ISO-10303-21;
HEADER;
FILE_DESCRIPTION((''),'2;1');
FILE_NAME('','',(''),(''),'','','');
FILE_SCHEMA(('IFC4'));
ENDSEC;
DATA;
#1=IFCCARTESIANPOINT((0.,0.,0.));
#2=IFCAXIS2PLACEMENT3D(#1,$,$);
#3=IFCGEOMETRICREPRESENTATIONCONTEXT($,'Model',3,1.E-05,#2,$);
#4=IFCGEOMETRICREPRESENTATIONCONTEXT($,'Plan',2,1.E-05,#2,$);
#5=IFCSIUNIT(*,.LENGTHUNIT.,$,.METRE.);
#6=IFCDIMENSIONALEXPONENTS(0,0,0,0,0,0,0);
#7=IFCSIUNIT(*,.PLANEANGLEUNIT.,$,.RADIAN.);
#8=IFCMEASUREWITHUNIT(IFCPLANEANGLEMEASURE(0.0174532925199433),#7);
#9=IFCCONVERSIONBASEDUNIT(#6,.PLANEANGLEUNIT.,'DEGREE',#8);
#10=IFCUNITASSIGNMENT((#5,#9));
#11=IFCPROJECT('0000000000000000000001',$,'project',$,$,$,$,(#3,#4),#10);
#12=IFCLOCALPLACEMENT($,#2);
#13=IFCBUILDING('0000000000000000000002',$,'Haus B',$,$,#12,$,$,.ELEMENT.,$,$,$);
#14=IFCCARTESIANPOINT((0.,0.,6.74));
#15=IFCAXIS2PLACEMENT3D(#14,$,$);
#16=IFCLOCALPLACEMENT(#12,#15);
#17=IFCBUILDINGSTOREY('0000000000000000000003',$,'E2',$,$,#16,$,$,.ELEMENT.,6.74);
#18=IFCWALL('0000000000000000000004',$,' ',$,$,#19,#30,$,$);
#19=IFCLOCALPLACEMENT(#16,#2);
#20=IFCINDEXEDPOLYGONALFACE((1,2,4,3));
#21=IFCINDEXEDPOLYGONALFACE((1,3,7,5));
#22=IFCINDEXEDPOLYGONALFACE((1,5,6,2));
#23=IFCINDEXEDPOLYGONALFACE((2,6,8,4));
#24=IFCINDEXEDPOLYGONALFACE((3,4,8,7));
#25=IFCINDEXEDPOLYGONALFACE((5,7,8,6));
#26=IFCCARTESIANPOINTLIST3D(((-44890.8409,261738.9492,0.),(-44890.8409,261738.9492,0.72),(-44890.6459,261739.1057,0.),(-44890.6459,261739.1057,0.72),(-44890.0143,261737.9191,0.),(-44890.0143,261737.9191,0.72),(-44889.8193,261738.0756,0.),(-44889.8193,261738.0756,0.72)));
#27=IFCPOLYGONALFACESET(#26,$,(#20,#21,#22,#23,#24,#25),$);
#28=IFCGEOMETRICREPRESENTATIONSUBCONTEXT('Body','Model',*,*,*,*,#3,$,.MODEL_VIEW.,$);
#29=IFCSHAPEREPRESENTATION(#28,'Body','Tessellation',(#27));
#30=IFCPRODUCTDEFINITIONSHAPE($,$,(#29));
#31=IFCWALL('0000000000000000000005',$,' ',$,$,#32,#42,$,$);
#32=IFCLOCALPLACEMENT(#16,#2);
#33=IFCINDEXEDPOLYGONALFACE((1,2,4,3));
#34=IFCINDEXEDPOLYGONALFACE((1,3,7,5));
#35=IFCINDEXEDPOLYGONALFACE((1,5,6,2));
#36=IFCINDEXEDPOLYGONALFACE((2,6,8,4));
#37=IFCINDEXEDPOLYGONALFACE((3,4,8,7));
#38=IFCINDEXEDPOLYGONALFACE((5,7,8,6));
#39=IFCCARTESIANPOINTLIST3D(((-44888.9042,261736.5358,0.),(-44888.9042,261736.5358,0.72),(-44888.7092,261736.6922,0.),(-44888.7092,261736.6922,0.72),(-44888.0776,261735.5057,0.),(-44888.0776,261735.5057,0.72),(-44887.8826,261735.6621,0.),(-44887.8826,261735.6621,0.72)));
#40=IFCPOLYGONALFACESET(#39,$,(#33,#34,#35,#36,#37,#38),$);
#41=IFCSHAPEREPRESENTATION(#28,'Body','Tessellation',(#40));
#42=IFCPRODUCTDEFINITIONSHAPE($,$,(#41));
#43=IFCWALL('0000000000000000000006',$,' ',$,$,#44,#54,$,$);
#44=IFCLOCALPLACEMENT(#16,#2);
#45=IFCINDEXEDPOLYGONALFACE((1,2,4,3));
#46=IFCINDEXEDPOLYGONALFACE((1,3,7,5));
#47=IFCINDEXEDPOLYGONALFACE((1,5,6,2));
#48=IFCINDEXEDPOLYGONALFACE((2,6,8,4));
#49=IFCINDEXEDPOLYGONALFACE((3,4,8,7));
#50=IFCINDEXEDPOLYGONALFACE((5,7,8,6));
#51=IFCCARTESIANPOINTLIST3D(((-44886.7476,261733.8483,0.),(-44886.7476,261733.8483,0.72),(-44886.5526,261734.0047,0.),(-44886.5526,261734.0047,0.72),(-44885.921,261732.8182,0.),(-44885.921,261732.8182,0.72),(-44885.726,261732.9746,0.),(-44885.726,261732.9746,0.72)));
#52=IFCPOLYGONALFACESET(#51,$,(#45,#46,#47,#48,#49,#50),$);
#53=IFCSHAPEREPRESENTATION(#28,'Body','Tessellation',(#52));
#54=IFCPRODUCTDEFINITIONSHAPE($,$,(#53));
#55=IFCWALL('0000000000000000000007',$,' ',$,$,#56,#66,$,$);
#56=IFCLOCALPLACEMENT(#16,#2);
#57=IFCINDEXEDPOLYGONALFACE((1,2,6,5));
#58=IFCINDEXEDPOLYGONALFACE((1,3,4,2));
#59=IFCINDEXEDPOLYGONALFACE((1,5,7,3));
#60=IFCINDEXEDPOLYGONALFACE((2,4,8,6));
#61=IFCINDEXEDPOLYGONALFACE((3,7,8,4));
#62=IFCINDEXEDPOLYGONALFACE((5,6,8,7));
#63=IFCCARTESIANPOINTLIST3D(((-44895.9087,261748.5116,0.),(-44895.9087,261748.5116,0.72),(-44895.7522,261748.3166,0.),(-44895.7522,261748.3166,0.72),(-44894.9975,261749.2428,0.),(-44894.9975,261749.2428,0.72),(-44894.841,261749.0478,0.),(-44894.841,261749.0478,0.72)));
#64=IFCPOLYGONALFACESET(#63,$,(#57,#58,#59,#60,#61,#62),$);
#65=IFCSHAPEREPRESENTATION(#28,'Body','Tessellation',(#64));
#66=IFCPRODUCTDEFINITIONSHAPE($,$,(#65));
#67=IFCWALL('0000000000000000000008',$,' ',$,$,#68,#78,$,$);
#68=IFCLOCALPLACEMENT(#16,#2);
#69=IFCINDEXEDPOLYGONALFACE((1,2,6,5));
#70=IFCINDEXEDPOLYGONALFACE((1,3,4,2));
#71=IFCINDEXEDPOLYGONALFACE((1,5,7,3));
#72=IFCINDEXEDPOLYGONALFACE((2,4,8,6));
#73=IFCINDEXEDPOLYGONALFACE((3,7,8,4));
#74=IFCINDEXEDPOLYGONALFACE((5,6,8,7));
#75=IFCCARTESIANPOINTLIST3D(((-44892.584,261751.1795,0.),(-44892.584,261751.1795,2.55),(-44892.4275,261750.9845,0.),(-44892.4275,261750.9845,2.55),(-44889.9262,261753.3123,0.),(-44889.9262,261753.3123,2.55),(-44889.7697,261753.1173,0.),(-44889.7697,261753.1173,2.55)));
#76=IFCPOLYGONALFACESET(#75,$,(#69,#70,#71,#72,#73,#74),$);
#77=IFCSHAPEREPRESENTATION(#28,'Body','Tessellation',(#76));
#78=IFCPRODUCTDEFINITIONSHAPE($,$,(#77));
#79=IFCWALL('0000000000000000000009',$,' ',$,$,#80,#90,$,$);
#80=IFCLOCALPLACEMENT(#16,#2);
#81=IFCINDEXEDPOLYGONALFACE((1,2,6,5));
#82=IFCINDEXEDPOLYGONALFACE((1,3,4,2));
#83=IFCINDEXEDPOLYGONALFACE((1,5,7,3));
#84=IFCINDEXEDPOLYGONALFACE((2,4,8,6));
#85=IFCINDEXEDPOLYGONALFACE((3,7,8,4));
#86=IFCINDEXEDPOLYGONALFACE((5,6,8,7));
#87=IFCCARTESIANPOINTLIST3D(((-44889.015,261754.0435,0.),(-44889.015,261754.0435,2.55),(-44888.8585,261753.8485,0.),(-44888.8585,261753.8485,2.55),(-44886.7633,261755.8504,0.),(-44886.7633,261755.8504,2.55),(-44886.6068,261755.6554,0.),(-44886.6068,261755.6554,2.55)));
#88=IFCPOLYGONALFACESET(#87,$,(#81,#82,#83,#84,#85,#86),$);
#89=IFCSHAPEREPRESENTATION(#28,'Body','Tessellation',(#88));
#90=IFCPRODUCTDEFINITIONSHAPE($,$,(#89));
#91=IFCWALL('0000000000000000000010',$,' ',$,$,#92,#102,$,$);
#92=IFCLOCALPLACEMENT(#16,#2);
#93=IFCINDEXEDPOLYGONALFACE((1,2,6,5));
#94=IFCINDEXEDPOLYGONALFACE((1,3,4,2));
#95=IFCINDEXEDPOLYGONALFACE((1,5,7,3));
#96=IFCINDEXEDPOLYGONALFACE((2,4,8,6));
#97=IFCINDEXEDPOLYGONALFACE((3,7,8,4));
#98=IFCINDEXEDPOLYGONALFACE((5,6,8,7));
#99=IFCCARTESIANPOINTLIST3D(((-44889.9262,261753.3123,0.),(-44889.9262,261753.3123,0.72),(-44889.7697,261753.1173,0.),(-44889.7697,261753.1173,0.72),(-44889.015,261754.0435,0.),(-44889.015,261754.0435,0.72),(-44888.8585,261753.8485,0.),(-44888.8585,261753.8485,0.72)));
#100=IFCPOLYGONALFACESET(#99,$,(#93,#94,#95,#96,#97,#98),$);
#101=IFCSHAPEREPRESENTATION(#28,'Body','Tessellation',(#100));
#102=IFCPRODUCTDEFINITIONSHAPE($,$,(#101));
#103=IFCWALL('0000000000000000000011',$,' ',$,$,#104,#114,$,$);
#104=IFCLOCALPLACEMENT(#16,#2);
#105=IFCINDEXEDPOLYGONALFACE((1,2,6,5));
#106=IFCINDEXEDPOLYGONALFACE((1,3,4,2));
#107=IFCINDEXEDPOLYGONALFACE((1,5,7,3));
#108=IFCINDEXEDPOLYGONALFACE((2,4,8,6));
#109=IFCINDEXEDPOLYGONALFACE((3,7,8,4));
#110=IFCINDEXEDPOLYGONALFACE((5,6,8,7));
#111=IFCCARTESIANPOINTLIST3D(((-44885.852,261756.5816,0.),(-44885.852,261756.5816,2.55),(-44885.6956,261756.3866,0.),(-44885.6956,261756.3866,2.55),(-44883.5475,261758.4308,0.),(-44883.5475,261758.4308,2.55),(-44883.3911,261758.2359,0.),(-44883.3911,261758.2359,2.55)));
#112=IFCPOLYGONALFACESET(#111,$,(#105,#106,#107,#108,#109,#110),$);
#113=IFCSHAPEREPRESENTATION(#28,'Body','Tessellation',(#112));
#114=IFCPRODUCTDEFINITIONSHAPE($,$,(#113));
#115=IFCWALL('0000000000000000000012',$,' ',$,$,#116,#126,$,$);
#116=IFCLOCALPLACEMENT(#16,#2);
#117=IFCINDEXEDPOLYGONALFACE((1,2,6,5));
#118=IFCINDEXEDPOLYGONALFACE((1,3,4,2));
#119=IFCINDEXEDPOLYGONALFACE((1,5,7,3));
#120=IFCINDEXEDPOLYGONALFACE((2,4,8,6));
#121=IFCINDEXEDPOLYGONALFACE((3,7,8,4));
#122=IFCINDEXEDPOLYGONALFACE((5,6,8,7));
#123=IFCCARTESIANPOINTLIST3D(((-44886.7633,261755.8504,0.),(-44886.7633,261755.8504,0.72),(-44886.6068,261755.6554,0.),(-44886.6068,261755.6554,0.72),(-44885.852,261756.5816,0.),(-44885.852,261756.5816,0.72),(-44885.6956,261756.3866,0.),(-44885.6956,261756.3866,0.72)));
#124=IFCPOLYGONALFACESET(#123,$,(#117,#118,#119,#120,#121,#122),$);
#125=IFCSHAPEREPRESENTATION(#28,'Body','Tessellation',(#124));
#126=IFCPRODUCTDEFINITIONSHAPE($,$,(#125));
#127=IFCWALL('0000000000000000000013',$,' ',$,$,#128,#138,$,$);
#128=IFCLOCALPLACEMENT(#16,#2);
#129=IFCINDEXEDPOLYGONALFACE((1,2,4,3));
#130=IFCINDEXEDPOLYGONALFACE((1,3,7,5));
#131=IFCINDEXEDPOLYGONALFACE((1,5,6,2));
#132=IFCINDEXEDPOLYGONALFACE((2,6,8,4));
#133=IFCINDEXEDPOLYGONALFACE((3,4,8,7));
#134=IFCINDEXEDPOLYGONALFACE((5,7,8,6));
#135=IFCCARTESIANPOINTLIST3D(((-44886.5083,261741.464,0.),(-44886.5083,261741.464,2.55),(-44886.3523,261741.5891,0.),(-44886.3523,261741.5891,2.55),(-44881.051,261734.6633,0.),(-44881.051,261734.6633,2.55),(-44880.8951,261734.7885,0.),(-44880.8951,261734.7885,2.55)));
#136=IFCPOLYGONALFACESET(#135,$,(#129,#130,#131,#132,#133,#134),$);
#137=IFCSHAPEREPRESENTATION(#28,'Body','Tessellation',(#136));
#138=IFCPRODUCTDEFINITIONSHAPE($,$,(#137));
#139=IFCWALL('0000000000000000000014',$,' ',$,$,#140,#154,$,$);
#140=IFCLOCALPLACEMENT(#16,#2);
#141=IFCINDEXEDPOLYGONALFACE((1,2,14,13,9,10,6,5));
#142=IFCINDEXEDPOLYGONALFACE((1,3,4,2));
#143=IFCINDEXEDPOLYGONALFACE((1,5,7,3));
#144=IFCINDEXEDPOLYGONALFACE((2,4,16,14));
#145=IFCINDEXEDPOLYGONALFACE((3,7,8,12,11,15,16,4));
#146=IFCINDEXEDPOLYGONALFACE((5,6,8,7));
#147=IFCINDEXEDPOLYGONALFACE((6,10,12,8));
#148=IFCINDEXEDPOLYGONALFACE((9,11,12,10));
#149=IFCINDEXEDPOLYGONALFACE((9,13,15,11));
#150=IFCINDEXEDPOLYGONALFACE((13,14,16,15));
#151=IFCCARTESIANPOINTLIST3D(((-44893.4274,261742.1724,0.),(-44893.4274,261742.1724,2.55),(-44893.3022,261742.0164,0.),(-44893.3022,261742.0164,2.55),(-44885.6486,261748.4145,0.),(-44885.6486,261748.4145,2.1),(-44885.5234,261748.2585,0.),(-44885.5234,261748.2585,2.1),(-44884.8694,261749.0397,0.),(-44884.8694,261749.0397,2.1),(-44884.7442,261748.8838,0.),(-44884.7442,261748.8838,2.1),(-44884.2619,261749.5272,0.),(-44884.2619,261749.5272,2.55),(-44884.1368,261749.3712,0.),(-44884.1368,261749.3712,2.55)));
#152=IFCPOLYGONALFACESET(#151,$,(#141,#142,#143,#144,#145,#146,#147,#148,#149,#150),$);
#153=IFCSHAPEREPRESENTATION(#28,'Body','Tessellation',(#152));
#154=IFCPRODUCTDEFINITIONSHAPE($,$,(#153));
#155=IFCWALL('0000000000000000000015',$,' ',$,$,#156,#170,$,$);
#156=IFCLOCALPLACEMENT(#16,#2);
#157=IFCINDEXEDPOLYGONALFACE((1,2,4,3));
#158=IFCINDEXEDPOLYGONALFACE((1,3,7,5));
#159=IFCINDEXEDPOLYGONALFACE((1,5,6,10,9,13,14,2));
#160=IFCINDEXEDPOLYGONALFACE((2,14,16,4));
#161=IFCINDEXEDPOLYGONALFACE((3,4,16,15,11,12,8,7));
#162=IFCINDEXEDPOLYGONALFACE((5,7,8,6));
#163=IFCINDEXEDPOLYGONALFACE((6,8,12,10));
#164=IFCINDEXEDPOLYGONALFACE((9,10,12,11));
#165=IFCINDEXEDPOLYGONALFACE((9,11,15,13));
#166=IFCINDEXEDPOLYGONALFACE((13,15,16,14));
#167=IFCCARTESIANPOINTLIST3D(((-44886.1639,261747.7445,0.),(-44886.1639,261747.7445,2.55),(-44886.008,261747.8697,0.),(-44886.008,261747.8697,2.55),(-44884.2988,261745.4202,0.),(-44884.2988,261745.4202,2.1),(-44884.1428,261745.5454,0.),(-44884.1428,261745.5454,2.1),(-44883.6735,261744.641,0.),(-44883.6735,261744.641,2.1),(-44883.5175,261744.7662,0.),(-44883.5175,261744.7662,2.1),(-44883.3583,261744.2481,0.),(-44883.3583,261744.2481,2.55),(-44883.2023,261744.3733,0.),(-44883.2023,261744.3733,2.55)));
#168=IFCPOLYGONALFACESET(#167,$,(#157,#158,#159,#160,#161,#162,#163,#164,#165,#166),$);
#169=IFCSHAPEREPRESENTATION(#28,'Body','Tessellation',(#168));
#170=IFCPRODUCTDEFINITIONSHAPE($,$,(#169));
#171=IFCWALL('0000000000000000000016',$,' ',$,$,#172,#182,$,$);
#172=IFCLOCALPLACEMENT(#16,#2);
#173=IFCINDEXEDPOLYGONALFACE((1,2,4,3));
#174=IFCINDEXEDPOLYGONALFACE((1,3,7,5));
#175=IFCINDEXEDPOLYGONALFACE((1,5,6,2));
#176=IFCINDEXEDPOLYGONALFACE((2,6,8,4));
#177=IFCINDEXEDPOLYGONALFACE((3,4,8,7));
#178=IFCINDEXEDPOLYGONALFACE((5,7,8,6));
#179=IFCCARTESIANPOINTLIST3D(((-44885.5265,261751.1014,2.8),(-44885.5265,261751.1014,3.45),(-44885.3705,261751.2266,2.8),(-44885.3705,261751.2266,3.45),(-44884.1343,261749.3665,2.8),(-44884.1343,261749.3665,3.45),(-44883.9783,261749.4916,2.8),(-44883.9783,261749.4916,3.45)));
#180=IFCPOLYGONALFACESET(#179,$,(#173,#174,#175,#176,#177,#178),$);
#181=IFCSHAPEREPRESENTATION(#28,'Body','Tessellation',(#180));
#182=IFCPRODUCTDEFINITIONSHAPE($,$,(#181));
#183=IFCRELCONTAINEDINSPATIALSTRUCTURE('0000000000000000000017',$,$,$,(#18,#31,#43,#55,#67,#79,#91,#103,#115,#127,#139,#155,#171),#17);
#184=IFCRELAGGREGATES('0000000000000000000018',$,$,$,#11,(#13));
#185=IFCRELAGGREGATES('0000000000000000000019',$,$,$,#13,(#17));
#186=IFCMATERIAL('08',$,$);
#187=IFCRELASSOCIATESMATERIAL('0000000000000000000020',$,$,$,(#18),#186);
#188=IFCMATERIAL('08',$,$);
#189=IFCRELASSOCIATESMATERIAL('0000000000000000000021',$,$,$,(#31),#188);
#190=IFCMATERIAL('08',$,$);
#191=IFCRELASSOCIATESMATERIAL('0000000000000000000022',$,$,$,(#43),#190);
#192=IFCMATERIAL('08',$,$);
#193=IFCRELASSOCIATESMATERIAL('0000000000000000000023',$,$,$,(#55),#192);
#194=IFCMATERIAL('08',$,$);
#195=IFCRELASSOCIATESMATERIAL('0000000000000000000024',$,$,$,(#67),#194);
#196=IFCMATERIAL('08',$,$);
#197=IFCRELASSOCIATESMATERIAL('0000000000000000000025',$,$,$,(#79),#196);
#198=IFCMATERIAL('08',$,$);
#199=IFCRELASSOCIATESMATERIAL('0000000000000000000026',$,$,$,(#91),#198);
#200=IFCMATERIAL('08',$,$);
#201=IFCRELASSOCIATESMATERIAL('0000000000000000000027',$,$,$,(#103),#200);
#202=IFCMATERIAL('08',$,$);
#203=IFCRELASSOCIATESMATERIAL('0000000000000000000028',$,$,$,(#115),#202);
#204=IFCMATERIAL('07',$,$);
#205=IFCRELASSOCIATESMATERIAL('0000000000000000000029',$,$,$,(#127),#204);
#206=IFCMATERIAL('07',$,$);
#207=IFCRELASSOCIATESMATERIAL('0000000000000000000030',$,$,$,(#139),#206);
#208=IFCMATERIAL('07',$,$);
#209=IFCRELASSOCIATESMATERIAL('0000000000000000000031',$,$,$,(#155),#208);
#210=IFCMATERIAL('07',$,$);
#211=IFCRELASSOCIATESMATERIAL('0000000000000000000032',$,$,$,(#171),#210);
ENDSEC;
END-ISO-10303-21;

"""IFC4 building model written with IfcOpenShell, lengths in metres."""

from ifc_helpers import new_model, entity, si_unit, converted_unit, frame, frame_2d, origin, origin_with_axes, place, context, subcontext, project, spatial, polyline, rectangle, outline, extrude, material, element, save


model = new_model("IFC4")

# Units and contexts
model_context = context("Model", 3, precision=1e-05, world=origin())
plan_context = context("Plan", 2, precision=1e-05, world=origin())
body_context = subcontext(model_context, "Body", "Model", "MODEL_VIEW")
ifc_project = project(units=[si_unit("LENGTHUNIT", "METRE"), converted_unit("PLANEANGLEUNIT", "DEGREE", entity("IfcPlaneAngleMeasure", 0.0174532925199433), si_unit("PLANEANGLEUNIT", "RADIAN"), dimensions=[0, 0, 0, 0, 0, 0, 0])], contexts=[model_context, plan_context])

# Building, storey
building_placement = place(None, origin())
building = spatial("IfcBuilding", under=ifc_project, at=building_placement, Name="Haus B", CompositionType="ELEMENT")
storey_placement = place(building_placement, frame((0.0, 0.0, 6.74)))
storey = spatial("IfcBuildingStorey", under=building, at=storey_placement, Name="E2", CompositionType="ELEMENT", Elevation=6.74)

# Walls
ifc_material_1 = material(Name="08")
wall_1_placement = place(storey_placement, frame((-44889.8193, 261738.0756, 0.0), z_axis=(0.0, 0.0, 1.0), x_axis=(-0.625861, 0.779935, 0.0)))
element("IfcWall", 1, at=wall_1_placement, inside=storey, material=ifc_material_1, Name=" ", context=body_context, shape_type="SweptSolid", body=[
    extrude(rectangle(XDim=1.3207, YDim=0.25, at=frame_2d((0.6604, 0.125), x_axis=(1.0, 0.0))), origin_with_axes(), (0.0, 0.0, 1.0), 0.72),
])
ifc_material_2 = material(Name="08")
wall_2_placement = place(storey_placement, frame((-44887.8826, 261735.6621, 0.0), z_axis=(0.0, 0.0, 1.0), x_axis=(-0.625861, 0.779935, 0.0)))
element("IfcWall", 2, at=wall_2_placement, inside=storey, material=ifc_material_2, Name=" ", context=body_context, shape_type="SweptSolid", body=[
    extrude(rectangle(XDim=1.3207, YDim=0.25, at=frame_2d((0.6604, 0.125), x_axis=(1.0, 0.0))), origin_with_axes(), (0.0, 0.0, 1.0), 0.72),
])
ifc_material_3 = material(Name="08")
wall_3_placement = place(storey_placement, frame((-44885.726, 261732.9746, 0.0), z_axis=(0.0, 0.0, 1.0), x_axis=(-0.625861, 0.779935, 0.0)))
element("IfcWall", 3, at=wall_3_placement, inside=storey, material=ifc_material_3, Name=" ", context=body_context, shape_type="SweptSolid", body=[
    extrude(rectangle(XDim=1.3207, YDim=0.25, at=frame_2d((0.6604, 0.125), x_axis=(1.0, 0.0))), origin_with_axes(), (0.0, 0.0, 1.0), 0.72),
])
ifc_material_4 = material(Name="08")
wall_4_placement = place(storey_placement, frame((-44895.7522, 261748.3166, 0.0), z_axis=(0.0, 0.0, 1.0), x_axis=(0.779935, 0.625861, 0.0)))
element("IfcWall", 4, at=wall_4_placement, inside=storey, material=ifc_material_4, Name=" ", context=body_context, shape_type="SweptSolid", body=[
    extrude(rectangle(XDim=1.1684, YDim=0.25, at=frame_2d((0.5842, 0.125), x_axis=(1.0, 0.0))), origin_with_axes(), (0.0, 0.0, 1.0), 0.72),
])
ifc_material_5 = material(Name="08")
wall_5_placement = place(storey_placement, frame((-44892.4275, 261750.9845, 0.0), z_axis=(0.0, 0.0, 1.0), x_axis=(0.779935, 0.625861, 0.0)))
element("IfcWall", 5, at=wall_5_placement, inside=storey, material=ifc_material_5, Name=" ", context=body_context, shape_type="SweptSolid", body=[
    extrude(rectangle(XDim=3.4077, YDim=0.25, at=frame_2d((1.7039, 0.125), x_axis=(1.0, 0.0))), origin_with_axes(), (0.0, 0.0, 1.0), 2.55),
])
ifc_material_6 = material(Name="08")
wall_6_placement = place(storey_placement, frame((-44888.8585, 261753.8485, 0.0), z_axis=(0.0, 0.0, 1.0), x_axis=(0.779935, 0.625861, 0.0)))
element("IfcWall", 6, at=wall_6_placement, inside=storey, material=ifc_material_6, Name=" ", context=body_context, shape_type="SweptSolid", body=[
    extrude(rectangle(XDim=2.887, YDim=0.25, at=frame_2d((1.4435, 0.125), x_axis=(1.0, 0.0))), origin_with_axes(), (0.0, 0.0, 1.0), 2.55),
])
ifc_material_7 = material(Name="08")
wall_7_placement = place(storey_placement, frame((-44889.7697, 261753.1173, 0.0), z_axis=(0.0, 0.0, 1.0), x_axis=(0.779935, 0.625861, 0.0)))
element("IfcWall", 7, at=wall_7_placement, inside=storey, material=ifc_material_7, Name=" ", context=body_context, shape_type="SweptSolid", body=[
    extrude(rectangle(XDim=1.1684, YDim=0.25, at=frame_2d((0.5842, 0.125), x_axis=(1.0, 0.0))), origin_with_axes(), (0.0, 0.0, 1.0), 0.72),
])
ifc_material_8 = material(Name="08")
wall_8_placement = place(storey_placement, frame((-44885.6956, 261756.3866, 0.0), z_axis=(0.0, 0.0, 1.0), x_axis=(0.779935, 0.625861, 0.0)))
element("IfcWall", 8, at=wall_8_placement, inside=storey, material=ifc_material_8, Name=" ", context=body_context, shape_type="SweptSolid", body=[
    extrude(rectangle(XDim=2.9548, YDim=0.25, at=frame_2d((1.4774, 0.125), x_axis=(1.0, 0.0))), origin_with_axes(), (0.0, 0.0, 1.0), 2.55),
])
ifc_material_9 = material(Name="08")
wall_9_placement = place(storey_placement, frame((-44886.6068, 261755.6554, 0.0), z_axis=(0.0, 0.0, 1.0), x_axis=(0.779935, 0.625861, 0.0)))
element("IfcWall", 9, at=wall_9_placement, inside=storey, material=ifc_material_9, Name=" ", context=body_context, shape_type="SweptSolid", body=[
    extrude(rectangle(XDim=1.1684, YDim=0.25, at=frame_2d((0.5842, 0.125), x_axis=(1.0, 0.0))), origin_with_axes(), (0.0, 0.0, 1.0), 0.72),
])
ifc_material_10 = material(Name="07")
wall_10_placement = place(storey_placement, frame((-44886.5083, 261741.464, 0.0), z_axis=(0.0, 0.0, 1.0), x_axis=(0.625861, -0.779935, 0.0)))
element("IfcWall", 10, at=wall_10_placement, inside=storey, material=ifc_material_10, Name=" ", context=body_context, shape_type="SweptSolid", body=[
    extrude(rectangle(XDim=8.7195, YDim=0.2, at=frame_2d((4.3598, 0.1), x_axis=(1.0, 0.0))), origin_with_axes(), (0.0, 0.0, 1.0), 2.55),
])

# Walls, openings
ifc_material_11 = material(Name="07")
wall_11_placement = place(storey_placement, frame((-44893.3022, 261742.0164, 0.0), z_axis=(0.0, 0.0, 1.0), x_axis=(0.779935, 0.625861, 0.0)))
wall_11 = element("IfcWall", 11, at=wall_11_placement, inside=storey, material=ifc_material_11, Name=" ", context=body_context, shape_type="SweptSolid", body=[
    extrude(rectangle(XDim=11.7515, YDim=0.2, at=frame_2d((5.8758, 0.1), x_axis=(1.0, 0.0))), origin_with_axes(), (0.0, 0.0, 1.0), 2.55),
])
opening_1_placement = place(wall_11_placement, frame((9.9736, 0.0, 0.0), z_axis=(0.0, 1.0, 0.0), x_axis=(0.0, 0.0, 1.0)))
element("IfcOpeningElement", 12, at=opening_1_placement, cuts=wall_11, ObjectType="Opening", context=body_context, shape_type="SweptSolid", body=[
    extrude(outline(polyline([(0.0, 0.999), (2.1, 0.999), (2.1, 0.0), (0.0, 0.0), (0.0, 0.999)])), origin_with_axes(), (0.0, 0.0, 1.0), 0.2),
])
ifc_material_12 = material(Name="07")
wall_12_placement = place(storey_placement, frame((-44886.1639, 261747.7445, 0.0), z_axis=(0.0, 0.0, 1.0), x_axis=(0.625861, -0.779935, 0.0)))
wall_12 = element("IfcWall", 13, at=wall_12_placement, inside=storey, material=ifc_material_12, Name=" ", context=body_context, shape_type="SweptSolid", body=[
    extrude(rectangle(XDim=4.4829, YDim=0.2, at=frame_2d((2.2415, 0.1), x_axis=(1.0, 0.0))), origin_with_axes(), (0.0, 0.0, 1.0), 2.55),
])
opening_2_placement = place(wall_12_placement, frame((3.9792, 0.2, 0.0), z_axis=(0.0, -1.0, 0.0), x_axis=(0.0, 0.0, 1.0)))
element("IfcOpeningElement", 14, at=opening_2_placement, cuts=wall_12, ObjectType="Opening", context=body_context, shape_type="SweptSolid", body=[
    extrude(outline(polyline([(0.0, 0.999), (2.1, 0.999), (2.1, 0.0), (0.0, 0.0), (0.0, 0.999)])), origin_with_axes(), (0.0, 0.0, 1.0), 0.2),
])

# Wall
ifc_material_13 = material(Name="07")
wall_13_placement = place(storey_placement, frame((-44883.9783, 261749.4916, 2.8), z_axis=(0.0, 0.0, 1.0), x_axis=(-0.625861, 0.779935, 0.0)))
element("IfcWall", 15, at=wall_13_placement, inside=storey, material=ifc_material_13, Name=" ", context=body_context, shape_type="SweptSolid", body=[
    extrude(rectangle(XDim=2.2245, YDim=0.2, at=frame_2d((1.1122, 0.1), x_axis=(1.0, 0.0))), origin_with_axes(), (0.0, 0.0, 1.0), 0.65),
])

save(model, "model.ifc")
